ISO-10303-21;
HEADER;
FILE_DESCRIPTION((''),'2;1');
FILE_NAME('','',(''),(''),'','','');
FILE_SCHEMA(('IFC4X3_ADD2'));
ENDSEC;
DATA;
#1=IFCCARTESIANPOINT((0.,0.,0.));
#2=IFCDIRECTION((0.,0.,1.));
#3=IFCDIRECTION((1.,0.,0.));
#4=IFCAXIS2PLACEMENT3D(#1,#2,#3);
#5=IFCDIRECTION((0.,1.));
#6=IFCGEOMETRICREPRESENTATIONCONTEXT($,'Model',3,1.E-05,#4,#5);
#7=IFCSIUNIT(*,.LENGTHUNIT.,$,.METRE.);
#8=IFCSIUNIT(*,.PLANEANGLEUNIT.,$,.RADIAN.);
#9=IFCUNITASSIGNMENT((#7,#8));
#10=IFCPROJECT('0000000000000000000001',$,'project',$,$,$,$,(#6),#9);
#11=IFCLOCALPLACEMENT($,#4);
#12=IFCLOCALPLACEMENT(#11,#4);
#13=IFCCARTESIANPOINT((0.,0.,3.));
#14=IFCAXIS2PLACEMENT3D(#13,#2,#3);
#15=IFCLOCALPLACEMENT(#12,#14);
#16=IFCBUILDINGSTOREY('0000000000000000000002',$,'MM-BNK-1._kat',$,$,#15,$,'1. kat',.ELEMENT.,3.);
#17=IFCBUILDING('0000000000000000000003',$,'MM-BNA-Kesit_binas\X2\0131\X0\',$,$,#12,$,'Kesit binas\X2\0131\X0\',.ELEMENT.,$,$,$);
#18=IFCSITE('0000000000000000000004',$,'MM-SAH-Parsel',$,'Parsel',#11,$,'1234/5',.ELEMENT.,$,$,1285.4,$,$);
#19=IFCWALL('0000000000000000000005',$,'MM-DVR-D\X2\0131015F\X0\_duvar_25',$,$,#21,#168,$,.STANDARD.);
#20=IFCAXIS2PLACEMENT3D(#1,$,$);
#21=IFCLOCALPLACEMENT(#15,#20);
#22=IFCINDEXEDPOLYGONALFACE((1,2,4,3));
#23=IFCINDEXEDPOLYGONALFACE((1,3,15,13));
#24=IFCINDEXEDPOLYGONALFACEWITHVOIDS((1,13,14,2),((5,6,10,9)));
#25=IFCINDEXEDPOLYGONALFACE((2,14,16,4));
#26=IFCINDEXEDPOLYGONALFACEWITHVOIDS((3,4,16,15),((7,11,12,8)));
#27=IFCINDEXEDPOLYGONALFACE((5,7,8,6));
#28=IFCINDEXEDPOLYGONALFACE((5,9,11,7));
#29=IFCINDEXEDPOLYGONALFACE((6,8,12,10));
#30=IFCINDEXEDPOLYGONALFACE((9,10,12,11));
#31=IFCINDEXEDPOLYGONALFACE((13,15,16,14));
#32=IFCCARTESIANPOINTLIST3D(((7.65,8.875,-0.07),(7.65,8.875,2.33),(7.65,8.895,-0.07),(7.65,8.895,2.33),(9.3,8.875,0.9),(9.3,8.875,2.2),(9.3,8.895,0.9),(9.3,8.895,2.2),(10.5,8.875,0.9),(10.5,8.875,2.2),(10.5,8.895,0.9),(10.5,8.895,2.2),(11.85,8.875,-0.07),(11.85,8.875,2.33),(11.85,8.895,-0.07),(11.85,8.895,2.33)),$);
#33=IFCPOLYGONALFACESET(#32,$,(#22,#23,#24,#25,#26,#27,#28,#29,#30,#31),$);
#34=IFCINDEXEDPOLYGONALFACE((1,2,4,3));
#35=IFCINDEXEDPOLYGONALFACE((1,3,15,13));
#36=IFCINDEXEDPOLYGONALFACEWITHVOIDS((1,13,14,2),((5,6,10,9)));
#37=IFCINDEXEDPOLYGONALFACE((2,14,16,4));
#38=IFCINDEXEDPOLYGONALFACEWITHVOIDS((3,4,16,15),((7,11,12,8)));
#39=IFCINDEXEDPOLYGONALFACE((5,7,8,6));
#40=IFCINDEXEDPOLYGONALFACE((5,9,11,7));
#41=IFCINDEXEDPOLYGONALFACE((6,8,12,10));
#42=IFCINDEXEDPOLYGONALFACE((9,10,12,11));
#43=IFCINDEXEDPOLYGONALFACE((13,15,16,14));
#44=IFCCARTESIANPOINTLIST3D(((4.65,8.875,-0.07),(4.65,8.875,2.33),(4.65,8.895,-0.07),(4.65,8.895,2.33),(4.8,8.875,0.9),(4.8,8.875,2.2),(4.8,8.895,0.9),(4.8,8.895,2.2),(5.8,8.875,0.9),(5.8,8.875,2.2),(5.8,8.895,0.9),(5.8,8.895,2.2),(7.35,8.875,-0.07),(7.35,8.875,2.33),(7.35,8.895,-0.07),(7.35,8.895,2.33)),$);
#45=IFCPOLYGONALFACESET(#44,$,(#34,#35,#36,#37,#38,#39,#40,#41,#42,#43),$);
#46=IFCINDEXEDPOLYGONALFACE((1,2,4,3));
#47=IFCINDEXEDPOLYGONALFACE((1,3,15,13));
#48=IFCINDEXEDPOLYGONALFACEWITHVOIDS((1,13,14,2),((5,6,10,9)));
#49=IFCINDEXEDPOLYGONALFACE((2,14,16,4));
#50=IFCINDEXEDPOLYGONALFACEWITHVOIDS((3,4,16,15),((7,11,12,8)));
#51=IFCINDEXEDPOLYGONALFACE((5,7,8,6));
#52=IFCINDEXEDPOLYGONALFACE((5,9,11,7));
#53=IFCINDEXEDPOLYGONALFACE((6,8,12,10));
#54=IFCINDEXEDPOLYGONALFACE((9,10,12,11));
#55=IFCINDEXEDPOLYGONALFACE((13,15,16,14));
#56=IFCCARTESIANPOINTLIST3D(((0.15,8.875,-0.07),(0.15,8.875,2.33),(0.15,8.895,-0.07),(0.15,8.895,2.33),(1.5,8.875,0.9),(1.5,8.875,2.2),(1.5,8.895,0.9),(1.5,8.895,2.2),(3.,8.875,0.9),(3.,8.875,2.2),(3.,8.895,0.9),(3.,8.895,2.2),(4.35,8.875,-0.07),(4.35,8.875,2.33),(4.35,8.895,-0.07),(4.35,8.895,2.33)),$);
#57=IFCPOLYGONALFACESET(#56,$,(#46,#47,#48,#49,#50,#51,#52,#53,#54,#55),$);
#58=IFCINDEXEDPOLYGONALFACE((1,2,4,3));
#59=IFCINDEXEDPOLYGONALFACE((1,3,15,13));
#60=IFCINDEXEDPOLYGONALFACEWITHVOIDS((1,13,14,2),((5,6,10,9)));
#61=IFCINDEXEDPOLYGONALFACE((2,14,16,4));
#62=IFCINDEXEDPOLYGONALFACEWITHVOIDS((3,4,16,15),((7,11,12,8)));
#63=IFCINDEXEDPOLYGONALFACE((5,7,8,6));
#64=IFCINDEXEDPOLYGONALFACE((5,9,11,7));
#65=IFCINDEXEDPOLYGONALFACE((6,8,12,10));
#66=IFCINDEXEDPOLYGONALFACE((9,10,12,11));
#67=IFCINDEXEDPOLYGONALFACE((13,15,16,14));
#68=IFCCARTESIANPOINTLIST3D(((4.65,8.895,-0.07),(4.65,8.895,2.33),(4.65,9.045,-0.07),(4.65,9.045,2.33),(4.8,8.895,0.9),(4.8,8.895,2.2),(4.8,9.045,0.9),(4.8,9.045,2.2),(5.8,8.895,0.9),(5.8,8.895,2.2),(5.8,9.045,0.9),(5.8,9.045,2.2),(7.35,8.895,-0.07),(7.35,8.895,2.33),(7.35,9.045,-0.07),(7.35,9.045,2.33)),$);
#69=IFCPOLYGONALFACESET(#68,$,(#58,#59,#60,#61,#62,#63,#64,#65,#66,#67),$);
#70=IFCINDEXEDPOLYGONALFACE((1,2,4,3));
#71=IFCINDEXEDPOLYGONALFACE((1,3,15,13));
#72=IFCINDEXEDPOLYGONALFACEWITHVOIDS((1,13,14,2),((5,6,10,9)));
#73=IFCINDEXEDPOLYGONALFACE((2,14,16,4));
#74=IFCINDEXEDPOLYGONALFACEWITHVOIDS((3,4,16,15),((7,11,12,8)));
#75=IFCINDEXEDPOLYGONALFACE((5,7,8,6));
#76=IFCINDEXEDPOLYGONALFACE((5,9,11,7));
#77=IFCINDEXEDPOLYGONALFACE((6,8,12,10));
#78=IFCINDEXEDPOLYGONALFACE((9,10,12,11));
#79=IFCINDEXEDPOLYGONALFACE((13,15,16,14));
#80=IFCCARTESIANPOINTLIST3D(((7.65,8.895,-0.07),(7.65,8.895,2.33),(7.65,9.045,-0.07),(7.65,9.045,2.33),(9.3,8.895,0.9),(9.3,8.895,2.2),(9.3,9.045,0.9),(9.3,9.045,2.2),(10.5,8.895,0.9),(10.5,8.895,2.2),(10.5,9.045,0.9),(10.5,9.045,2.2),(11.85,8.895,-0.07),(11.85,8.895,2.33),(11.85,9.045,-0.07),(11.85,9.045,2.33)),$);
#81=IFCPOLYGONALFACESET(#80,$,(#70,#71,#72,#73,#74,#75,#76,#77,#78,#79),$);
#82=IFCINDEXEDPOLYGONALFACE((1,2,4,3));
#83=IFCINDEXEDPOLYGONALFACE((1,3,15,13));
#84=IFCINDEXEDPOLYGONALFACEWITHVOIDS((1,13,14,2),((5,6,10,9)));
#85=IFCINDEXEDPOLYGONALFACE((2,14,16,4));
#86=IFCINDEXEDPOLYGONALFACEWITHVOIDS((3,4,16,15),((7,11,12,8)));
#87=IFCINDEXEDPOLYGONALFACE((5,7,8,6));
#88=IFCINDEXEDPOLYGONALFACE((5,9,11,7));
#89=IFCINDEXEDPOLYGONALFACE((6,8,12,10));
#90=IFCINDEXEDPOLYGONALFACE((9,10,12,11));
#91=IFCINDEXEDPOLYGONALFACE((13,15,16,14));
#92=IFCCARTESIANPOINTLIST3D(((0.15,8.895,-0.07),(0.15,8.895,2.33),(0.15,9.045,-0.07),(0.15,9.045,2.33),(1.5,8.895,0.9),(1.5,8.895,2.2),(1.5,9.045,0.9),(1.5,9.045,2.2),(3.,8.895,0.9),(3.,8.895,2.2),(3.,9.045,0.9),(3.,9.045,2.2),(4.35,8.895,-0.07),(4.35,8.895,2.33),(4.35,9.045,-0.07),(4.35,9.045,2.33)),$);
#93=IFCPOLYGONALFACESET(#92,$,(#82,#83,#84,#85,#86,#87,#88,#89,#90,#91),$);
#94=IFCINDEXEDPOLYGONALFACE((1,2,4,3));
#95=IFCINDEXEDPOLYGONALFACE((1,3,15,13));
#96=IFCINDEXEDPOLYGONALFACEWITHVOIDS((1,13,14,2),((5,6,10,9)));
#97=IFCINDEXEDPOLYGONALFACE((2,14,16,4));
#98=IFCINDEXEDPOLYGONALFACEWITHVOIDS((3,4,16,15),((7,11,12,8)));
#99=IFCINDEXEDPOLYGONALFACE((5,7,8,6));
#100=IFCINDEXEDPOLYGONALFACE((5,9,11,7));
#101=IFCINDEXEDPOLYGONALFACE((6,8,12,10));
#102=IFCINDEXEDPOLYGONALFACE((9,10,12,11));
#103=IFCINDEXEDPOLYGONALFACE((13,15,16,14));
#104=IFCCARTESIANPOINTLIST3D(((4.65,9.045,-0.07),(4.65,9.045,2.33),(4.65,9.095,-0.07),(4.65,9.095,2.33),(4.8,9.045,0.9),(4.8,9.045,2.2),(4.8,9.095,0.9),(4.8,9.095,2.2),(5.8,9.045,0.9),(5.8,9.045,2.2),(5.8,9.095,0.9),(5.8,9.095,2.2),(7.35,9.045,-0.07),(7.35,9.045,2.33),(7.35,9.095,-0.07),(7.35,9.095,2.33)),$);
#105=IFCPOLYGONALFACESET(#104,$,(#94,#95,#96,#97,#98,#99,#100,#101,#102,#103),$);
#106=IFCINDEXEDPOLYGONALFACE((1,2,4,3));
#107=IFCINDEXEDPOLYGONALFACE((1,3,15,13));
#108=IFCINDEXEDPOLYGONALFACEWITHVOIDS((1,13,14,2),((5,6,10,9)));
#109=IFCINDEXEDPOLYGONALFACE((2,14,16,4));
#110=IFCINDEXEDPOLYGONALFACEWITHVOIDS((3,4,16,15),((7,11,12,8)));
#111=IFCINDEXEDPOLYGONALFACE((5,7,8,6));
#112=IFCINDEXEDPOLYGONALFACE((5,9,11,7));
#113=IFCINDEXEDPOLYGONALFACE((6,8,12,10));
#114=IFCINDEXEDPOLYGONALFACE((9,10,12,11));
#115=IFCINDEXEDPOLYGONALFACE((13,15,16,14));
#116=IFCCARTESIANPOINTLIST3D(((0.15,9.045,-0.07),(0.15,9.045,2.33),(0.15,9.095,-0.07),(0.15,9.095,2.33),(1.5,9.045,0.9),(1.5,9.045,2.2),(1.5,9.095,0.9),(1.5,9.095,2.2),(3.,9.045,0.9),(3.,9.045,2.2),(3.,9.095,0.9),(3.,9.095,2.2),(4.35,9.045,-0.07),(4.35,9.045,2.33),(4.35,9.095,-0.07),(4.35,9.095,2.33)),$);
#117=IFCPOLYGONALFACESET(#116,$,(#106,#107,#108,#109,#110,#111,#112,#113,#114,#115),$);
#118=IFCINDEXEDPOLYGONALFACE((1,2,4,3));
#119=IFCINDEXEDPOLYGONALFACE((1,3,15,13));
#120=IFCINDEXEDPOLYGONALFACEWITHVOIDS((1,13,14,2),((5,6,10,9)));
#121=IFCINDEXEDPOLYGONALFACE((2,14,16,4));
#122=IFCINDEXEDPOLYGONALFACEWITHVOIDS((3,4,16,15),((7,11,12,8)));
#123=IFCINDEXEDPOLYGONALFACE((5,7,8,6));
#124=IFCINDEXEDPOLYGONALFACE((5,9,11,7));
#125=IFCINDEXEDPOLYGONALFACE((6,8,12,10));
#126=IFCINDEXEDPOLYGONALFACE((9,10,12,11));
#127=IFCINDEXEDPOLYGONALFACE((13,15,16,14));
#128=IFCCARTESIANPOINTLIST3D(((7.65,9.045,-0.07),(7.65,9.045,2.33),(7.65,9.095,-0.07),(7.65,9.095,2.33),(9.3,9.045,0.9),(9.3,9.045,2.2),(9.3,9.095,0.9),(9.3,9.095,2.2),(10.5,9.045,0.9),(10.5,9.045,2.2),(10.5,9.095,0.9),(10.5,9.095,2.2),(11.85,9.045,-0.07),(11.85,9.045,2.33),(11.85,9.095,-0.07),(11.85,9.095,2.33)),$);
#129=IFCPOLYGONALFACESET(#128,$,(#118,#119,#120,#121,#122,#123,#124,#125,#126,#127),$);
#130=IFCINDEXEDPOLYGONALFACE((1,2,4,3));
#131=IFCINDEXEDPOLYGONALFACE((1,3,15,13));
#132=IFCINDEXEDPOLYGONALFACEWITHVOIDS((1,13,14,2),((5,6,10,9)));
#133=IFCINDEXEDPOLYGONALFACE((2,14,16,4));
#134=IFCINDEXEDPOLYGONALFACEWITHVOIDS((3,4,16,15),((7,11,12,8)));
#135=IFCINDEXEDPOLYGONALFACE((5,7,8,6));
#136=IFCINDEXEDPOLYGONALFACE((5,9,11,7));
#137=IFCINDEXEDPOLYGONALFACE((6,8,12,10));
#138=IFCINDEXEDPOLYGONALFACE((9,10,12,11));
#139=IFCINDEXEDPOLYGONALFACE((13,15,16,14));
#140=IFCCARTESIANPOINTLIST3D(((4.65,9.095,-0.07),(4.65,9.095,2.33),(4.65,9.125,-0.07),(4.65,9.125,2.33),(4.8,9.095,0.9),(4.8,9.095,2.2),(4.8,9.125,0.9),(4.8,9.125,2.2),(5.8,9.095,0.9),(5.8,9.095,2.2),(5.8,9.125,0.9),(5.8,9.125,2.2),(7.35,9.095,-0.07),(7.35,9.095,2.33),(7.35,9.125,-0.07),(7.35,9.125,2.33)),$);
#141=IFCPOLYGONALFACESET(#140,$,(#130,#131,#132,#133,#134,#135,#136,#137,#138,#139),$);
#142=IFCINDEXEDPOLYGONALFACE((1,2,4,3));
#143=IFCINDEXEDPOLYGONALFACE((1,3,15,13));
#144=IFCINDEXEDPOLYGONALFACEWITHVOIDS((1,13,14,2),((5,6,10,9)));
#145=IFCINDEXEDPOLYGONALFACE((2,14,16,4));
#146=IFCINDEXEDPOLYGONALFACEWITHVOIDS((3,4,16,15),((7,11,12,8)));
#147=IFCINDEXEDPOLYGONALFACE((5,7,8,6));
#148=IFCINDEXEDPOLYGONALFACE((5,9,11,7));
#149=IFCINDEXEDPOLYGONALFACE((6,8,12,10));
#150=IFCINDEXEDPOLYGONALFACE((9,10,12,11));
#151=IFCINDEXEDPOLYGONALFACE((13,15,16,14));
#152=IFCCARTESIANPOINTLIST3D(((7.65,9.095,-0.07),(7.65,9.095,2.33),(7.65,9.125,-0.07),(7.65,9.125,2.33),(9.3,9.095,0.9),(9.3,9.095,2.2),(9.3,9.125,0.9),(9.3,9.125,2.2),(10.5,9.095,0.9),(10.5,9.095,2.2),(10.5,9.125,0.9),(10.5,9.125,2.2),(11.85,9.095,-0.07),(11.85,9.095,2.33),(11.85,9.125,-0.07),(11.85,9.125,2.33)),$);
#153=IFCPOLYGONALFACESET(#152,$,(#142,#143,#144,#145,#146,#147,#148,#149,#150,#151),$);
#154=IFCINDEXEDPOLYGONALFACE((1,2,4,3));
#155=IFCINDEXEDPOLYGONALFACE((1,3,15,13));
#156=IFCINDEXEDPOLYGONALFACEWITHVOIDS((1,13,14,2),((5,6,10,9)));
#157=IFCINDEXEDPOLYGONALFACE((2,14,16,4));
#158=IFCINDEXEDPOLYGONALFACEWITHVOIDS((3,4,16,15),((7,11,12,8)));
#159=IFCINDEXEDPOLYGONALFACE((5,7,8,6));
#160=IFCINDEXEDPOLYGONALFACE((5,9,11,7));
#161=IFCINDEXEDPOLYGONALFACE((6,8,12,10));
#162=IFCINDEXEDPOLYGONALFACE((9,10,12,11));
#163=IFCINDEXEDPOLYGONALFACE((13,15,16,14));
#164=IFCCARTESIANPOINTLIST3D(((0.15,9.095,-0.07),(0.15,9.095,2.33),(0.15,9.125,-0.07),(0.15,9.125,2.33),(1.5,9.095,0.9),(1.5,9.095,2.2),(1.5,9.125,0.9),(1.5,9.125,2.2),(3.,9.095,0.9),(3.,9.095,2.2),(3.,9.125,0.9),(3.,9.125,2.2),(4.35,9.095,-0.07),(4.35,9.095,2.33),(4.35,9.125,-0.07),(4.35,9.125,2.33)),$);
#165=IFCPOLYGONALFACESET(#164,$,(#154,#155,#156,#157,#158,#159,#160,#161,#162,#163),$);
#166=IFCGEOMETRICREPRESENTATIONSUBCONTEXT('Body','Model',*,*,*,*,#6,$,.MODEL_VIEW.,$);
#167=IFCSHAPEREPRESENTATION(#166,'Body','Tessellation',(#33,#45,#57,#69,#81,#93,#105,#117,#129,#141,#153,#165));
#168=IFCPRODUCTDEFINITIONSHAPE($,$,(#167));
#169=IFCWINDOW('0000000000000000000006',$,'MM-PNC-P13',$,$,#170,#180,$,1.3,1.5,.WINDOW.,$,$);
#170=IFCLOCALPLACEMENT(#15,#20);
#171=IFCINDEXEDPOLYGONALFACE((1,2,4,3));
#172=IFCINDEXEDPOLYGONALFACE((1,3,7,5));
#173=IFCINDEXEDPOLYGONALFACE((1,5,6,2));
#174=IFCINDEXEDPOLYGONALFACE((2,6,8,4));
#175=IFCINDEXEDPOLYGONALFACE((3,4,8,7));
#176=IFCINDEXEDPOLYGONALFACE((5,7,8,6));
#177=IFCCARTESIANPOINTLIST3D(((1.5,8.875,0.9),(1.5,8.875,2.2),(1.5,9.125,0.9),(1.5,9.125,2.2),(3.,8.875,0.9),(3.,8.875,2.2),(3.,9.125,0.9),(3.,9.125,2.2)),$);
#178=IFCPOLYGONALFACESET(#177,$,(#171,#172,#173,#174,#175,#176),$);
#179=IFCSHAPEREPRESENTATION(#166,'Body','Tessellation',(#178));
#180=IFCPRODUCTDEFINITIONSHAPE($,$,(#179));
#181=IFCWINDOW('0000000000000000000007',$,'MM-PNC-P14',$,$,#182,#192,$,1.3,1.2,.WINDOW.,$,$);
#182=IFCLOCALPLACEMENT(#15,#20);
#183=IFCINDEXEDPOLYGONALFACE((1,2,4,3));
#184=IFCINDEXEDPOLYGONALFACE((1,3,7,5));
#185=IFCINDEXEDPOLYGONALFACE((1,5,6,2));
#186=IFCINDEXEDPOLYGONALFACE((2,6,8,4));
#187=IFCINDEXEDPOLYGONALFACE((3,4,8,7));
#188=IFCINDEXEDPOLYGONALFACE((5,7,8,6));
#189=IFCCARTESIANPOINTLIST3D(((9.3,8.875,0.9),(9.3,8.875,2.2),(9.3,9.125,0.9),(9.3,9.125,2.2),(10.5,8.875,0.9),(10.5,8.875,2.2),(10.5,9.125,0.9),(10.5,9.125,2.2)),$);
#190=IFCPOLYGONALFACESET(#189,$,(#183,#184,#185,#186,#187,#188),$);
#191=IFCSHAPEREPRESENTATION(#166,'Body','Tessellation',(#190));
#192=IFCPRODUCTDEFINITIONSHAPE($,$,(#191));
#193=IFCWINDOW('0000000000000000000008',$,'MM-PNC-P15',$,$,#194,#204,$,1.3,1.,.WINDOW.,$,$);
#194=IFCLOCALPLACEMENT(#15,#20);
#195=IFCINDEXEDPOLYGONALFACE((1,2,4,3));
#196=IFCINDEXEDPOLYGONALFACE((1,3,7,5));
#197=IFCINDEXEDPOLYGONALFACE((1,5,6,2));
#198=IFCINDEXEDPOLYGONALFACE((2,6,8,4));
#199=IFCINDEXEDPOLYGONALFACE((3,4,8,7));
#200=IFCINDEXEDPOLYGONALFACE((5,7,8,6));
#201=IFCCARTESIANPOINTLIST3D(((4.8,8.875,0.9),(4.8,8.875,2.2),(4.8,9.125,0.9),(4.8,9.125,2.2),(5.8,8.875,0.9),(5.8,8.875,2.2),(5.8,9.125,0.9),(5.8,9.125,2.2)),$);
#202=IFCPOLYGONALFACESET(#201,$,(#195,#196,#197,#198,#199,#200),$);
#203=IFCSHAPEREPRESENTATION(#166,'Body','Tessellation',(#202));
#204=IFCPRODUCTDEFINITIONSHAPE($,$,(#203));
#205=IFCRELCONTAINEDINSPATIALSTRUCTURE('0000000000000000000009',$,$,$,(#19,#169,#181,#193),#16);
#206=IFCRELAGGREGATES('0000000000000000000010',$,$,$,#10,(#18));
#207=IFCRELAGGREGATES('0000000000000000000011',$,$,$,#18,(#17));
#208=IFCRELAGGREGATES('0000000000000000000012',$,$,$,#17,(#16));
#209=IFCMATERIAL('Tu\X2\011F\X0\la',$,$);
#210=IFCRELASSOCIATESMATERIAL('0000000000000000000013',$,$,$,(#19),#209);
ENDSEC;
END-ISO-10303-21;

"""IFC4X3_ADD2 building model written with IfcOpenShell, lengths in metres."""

from ifc_helpers import new_model, si_unit, direction, frame, origin_with_axes, place, context, subcontext, project, spatial, polyline, outline, extrude, material, element, fill, save


model = new_model("IFC4X3_ADD2")

# Units and contexts
model_context = context("Model", 3, precision=1e-05, world=origin_with_axes(), true_north=direction((0.0, 1.0)))
body_context = subcontext(model_context, "Body", "Model", "MODEL_VIEW")
ifc_project = project(units=[si_unit("LENGTHUNIT", "METRE"), si_unit("PLANEANGLEUNIT", "RADIAN")], contexts=[model_context])

# Site, building, storey
site_placement = place(None, origin_with_axes())
site = spatial("IfcSite", under=ifc_project, at=site_placement, Name="MM-SAH-Parsel", ObjectType="Parsel", LongName="1234/5", CompositionType="ELEMENT", RefElevation=1285.4)
building_placement = place(site_placement, origin_with_axes())
building = spatial("IfcBuilding", under=site, at=building_placement, Name="MM-BNA-Kesit_binası", LongName="Kesit binası", CompositionType="ELEMENT")
storey_placement = place(building_placement, frame((0.0, 0.0, 3.0), z_axis=(0.0, 0.0, 1.0), x_axis=(1.0, 0.0, 0.0)))
storey = spatial("IfcBuildingStorey", under=building, at=storey_placement, Name="MM-BNK-1._kat", LongName="1. kat", CompositionType="ELEMENT", Elevation=3.0)

# Shared definitions
ifc_material_1 = material(Name="Tuğla")

# Wall, openings, windows
wall_1_placement = place(storey_placement, origin_with_axes())
wall_1 = element("IfcWall", 1, at=wall_1_placement, inside=storey, material=ifc_material_1, Name="MM-DVR-Dış_duvar_25", PredefinedType="STANDARD", context=body_context, shape_type="SweptSolid", body=[
    extrude(outline(polyline([(11.85, 8.895), (7.65, 8.895), (7.65, 8.875), (11.85, 8.875), (11.85, 8.895)])), frame((0.0, 0.0, -0.07)), (0.0, 0.0, 1.0), 2.4),
    extrude(outline(polyline([(7.35, 8.895), (4.65, 8.895), (4.65, 8.875), (7.35, 8.875), (7.35, 8.895)])), frame((0.0, 0.0, -0.07)), (0.0, 0.0, 1.0), 2.4),
    extrude(outline(polyline([(4.35, 8.895), (0.15, 8.895), (0.15, 8.875), (4.35, 8.875), (4.35, 8.895)])), frame((0.0, 0.0, -0.07)), (0.0, 0.0, 1.0), 2.4),
    extrude(outline(polyline([(7.35, 9.045), (4.65, 9.045), (4.65, 8.895), (7.35, 8.895), (7.35, 9.045)])), frame((0.0, 0.0, -0.07)), (0.0, 0.0, 1.0), 2.4),
    extrude(outline(polyline([(11.85, 9.045), (7.65, 9.045), (7.65, 8.895), (11.85, 8.895), (11.85, 9.045)])), frame((0.0, 0.0, -0.07)), (0.0, 0.0, 1.0), 2.4),
    extrude(outline(polyline([(4.35, 9.045), (0.15, 9.045), (0.15, 8.895), (4.35, 8.895), (4.35, 9.045)])), frame((0.0, 0.0, -0.07)), (0.0, 0.0, 1.0), 2.4),
    extrude(outline(polyline([(7.35, 9.095), (4.65, 9.095), (4.65, 9.045), (7.35, 9.045), (7.35, 9.095)])), frame((0.0, 0.0, -0.07)), (0.0, 0.0, 1.0), 2.4),
    extrude(outline(polyline([(4.35, 9.095), (0.15, 9.095), (0.15, 9.045), (4.35, 9.045), (4.35, 9.095)])), frame((0.0, 0.0, -0.07)), (0.0, 0.0, 1.0), 2.4),
    extrude(outline(polyline([(11.85, 9.095), (7.65, 9.095), (7.65, 9.045), (11.85, 9.045), (11.85, 9.095)])), frame((0.0, 0.0, -0.07)), (0.0, 0.0, 1.0), 2.4),
    extrude(outline(polyline([(7.35, 9.125), (4.65, 9.125), (4.65, 9.095), (7.35, 9.095), (7.35, 9.125)])), frame((0.0, 0.0, -0.07)), (0.0, 0.0, 1.0), 2.4),
    extrude(outline(polyline([(11.85, 9.125), (7.65, 9.125), (7.65, 9.095), (11.85, 9.095), (11.85, 9.125)])), frame((0.0, 0.0, -0.07)), (0.0, 0.0, 1.0), 2.4),
    extrude(outline(polyline([(4.35, 9.125), (0.15, 9.125), (0.15, 9.095), (4.35, 9.095), (4.35, 9.125)])), frame((0.0, 0.0, -0.07)), (0.0, 0.0, 1.0), 2.4),
])
opening_1_placement = place(storey_placement, origin_with_axes())
opening_1 = element("IfcOpeningElement", 2, at=opening_1_placement, cuts=wall_1, PredefinedType="OPENING", context=body_context, shape_type="SweptSolid", body=[
    extrude(outline(polyline([(3.0, 8.875), (1.5, 8.875), (1.5, 9.125), (3.0, 9.125), (3.0, 8.875)])), frame((0.0, 0.0, 0.9)), (0.0, 0.0, 1.0), 1.3),
])
opening_2_placement = place(storey_placement, origin_with_axes())
opening_2 = element("IfcOpeningElement", 3, at=opening_2_placement, cuts=wall_1, PredefinedType="OPENING", context=body_context, shape_type="SweptSolid", body=[
    extrude(outline(polyline([(10.5, 8.875), (9.3, 8.875), (9.3, 9.125), (10.5, 9.125), (10.5, 8.875)])), frame((0.0, 0.0, 0.9)), (0.0, 0.0, 1.0), 1.3),
])
opening_3_placement = place(storey_placement, origin_with_axes())
opening_3 = element("IfcOpeningElement", 4, at=opening_3_placement, cuts=wall_1, PredefinedType="OPENING", context=body_context, shape_type="SweptSolid", body=[
    extrude(outline(polyline([(5.8, 8.875), (4.8, 8.875), (4.8, 9.125), (5.8, 9.125), (5.8, 8.875)])), frame((0.0, 0.0, 0.9)), (0.0, 0.0, 1.0), 1.3),
])
window_1_placement = place(storey_placement, origin_with_axes())
window_1 = element("IfcWindow", 5, at=window_1_placement, inside=storey, Name="MM-PNC-P13", OverallHeight=1.3, OverallWidth=1.5, PredefinedType="WINDOW", context=body_context, shape_type="SweptSolid", body=[
    extrude(outline(polyline([(3.0, 8.875), (1.5, 8.875), (1.5, 9.125), (3.0, 9.125), (3.0, 8.875)])), frame((0.0, 0.0, 0.9)), (0.0, 0.0, 1.0), 1.3),
])
fill(opening_1, window_1)
window_2_placement = place(storey_placement, origin_with_axes())
window_2 = element("IfcWindow", 6, at=window_2_placement, inside=storey, Name="MM-PNC-P14", OverallHeight=1.3, OverallWidth=1.2, PredefinedType="WINDOW", context=body_context, shape_type="SweptSolid", body=[
    extrude(outline(polyline([(10.5, 8.875), (9.3, 8.875), (9.3, 9.125), (10.5, 9.125), (10.5, 8.875)])), frame((0.0, 0.0, 0.9)), (0.0, 0.0, 1.0), 1.3),
])
fill(opening_2, window_2)
window_3_placement = place(storey_placement, origin_with_axes())
window_3 = element("IfcWindow", 7, at=window_3_placement, inside=storey, Name="MM-PNC-P15", OverallHeight=1.3, OverallWidth=1.0, PredefinedType="WINDOW", context=body_context, shape_type="SweptSolid", body=[
    extrude(outline(polyline([(5.8, 8.875), (4.8, 8.875), (4.8, 9.125), (5.8, 9.125), (5.8, 8.875)])), frame((0.0, 0.0, 0.9)), (0.0, 0.0, 1.0), 1.3),
])
fill(opening_3, window_3)

save(model, "model.ifc")
